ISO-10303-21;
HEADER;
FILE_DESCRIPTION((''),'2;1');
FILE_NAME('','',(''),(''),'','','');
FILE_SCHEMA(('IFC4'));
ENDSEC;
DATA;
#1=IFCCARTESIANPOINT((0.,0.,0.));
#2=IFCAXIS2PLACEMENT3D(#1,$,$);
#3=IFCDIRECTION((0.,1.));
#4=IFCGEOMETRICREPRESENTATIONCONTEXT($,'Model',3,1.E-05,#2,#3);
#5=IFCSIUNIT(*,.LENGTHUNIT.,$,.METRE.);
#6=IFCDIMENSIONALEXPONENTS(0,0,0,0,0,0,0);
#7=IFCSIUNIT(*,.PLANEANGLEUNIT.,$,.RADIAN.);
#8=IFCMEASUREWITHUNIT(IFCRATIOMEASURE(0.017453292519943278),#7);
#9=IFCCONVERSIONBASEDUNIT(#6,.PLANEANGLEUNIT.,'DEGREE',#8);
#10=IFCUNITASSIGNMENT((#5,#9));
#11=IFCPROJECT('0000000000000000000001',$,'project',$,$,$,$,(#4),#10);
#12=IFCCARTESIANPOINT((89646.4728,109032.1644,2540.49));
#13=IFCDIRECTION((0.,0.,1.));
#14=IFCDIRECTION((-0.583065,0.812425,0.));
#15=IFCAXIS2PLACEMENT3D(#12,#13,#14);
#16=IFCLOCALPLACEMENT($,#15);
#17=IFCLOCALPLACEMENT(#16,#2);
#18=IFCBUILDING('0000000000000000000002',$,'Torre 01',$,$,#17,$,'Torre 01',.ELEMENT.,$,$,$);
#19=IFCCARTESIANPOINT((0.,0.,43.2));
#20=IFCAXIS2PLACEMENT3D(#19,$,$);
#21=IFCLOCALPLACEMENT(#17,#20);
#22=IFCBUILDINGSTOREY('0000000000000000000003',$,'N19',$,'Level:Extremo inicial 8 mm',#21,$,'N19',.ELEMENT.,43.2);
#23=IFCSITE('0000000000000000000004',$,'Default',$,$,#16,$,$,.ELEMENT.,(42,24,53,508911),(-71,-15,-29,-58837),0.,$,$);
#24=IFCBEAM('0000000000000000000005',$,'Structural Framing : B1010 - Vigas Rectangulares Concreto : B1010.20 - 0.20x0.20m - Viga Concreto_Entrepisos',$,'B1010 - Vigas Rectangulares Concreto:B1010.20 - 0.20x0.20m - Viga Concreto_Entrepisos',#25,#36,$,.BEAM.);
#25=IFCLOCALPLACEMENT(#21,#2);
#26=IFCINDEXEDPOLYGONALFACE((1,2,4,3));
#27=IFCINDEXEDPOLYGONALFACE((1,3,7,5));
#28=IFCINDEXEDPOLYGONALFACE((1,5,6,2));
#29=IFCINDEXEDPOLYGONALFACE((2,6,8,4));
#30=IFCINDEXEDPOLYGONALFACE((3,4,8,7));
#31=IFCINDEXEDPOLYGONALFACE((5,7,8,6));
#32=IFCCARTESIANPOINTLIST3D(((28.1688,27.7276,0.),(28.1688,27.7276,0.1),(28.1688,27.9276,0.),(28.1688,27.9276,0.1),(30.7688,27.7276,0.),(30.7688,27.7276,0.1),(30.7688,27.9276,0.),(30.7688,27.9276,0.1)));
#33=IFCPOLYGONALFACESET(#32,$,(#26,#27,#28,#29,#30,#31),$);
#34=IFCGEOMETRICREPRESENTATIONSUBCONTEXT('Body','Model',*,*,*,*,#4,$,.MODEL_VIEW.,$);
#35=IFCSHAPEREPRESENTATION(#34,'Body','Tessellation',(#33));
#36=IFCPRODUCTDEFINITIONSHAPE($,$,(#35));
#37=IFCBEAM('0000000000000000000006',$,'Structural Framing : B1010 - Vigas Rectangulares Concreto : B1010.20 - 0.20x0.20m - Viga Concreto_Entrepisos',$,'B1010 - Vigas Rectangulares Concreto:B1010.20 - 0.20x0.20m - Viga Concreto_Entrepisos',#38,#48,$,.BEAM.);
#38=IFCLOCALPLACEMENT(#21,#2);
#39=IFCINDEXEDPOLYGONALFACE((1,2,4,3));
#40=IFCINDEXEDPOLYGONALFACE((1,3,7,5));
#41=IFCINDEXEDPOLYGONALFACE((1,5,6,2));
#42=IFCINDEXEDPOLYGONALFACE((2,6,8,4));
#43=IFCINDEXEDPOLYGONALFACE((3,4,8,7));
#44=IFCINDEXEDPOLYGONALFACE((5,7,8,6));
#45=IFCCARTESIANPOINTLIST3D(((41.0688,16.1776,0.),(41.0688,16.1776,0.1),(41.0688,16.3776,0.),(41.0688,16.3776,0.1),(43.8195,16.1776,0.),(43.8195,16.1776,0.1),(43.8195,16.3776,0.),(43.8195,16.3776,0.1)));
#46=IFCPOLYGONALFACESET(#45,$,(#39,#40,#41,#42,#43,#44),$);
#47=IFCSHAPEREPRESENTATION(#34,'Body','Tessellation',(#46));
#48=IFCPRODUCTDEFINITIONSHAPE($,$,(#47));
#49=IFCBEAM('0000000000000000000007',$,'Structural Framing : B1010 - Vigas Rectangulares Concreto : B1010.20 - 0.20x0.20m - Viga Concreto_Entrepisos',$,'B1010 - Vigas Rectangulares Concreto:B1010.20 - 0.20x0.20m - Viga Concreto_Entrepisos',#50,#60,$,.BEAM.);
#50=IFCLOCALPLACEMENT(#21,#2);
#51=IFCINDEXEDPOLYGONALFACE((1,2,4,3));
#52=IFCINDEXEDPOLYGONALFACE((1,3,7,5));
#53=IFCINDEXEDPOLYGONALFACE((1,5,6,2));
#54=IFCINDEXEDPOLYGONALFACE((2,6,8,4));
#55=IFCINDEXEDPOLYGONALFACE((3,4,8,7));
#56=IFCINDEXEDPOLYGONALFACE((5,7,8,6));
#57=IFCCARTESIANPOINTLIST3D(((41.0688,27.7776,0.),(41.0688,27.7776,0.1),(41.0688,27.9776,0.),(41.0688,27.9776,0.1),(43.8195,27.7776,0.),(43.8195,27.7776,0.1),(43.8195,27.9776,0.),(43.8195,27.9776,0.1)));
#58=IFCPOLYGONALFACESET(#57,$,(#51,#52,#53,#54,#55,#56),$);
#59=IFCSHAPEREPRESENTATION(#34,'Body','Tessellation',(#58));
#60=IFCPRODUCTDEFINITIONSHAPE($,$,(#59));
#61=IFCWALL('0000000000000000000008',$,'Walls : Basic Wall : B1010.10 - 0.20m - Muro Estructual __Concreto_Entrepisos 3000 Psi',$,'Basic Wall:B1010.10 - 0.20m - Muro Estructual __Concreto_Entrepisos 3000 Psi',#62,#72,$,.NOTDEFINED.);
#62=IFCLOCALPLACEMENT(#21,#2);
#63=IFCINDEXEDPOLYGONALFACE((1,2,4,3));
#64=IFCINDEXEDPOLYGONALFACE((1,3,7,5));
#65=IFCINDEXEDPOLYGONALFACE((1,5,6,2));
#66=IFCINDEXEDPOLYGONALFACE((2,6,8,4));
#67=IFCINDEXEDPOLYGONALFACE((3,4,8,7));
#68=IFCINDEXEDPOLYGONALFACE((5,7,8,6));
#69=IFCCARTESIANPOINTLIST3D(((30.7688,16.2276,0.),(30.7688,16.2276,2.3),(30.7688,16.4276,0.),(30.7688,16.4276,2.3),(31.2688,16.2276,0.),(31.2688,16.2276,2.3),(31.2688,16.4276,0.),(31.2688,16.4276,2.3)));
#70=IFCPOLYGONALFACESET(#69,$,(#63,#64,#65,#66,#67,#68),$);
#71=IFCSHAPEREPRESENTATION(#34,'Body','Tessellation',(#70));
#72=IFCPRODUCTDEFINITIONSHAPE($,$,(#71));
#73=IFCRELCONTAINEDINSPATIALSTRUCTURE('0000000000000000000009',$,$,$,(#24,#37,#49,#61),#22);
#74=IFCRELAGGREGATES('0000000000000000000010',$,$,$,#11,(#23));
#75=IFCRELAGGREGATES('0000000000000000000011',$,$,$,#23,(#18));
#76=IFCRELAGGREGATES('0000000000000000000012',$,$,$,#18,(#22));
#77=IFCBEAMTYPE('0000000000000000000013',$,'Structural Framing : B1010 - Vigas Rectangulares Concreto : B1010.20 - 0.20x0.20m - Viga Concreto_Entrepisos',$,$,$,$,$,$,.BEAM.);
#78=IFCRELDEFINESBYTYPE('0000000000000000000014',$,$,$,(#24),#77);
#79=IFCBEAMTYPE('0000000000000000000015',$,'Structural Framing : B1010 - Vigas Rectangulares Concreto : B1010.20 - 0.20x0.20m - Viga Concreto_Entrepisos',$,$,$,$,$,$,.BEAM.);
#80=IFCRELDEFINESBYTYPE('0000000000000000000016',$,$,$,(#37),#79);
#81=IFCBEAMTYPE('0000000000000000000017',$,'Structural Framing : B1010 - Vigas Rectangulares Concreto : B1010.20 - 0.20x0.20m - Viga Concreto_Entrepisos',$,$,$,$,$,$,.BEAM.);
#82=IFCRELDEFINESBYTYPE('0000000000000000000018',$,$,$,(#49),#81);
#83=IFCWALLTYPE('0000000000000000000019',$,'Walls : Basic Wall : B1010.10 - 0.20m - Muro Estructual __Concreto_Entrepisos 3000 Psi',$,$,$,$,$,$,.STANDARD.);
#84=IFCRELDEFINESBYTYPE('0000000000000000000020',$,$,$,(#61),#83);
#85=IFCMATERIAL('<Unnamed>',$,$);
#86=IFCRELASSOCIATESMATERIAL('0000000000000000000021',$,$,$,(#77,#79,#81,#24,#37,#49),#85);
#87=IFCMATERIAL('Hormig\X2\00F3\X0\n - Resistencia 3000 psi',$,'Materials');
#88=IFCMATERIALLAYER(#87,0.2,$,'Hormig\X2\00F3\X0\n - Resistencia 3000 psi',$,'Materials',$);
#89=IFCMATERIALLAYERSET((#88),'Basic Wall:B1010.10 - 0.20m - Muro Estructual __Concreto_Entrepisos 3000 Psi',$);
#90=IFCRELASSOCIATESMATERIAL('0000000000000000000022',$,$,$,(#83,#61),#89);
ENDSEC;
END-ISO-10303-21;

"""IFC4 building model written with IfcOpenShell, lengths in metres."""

from ifc_helpers import new_model, entity, si_unit, converted_unit, direction, frame, frame_2d, origin, origin_2d_with_axis, place, context, subcontext, project, spatial, polyline, segment, composite_curve, rectangle, outline, extrude, source, transform, mapped, material, layer, layer_set, layer_usage, material_profile, profile_set, profile_usage, type_object, type_shapes, element, save


model = new_model("IFC4")

# Units and contexts
model_context = context("Model", 3, precision=1e-05, world=origin(), true_north=direction((0.0, 1.0)))
body_context = subcontext(model_context, "Body", "Model", "MODEL_VIEW")
ifc_project = project(units=[si_unit("LENGTHUNIT", "METRE"), converted_unit("PLANEANGLEUNIT", "DEGREE", entity("IfcRatioMeasure", 0.017453292519943278), si_unit("PLANEANGLEUNIT", "RADIAN"), dimensions=[0, 0, 0, 0, 0, 0, 0])], contexts=[model_context])

# Site, building, storey
site_placement = place(None, frame((89646.4728, 109032.1644, 2540.49), z_axis=(0.0, 0.0, 1.0), x_axis=(-0.583065, 0.812425, 0.0)))
site = spatial("IfcSite", under=ifc_project, at=site_placement, Name="Default", CompositionType="ELEMENT", RefLatitude=(42, 24, 53, 508911), RefLongitude=(-71, -15, -29, -58837), RefElevation=0.0)
building_placement = place(site_placement, origin())
building = spatial("IfcBuilding", under=site, at=building_placement, Name="Torre 01", LongName="Torre 01", CompositionType="ELEMENT")
storey_placement = place(building_placement, frame((0.0, 0.0, 43.2)))
storey = spatial("IfcBuildingStorey", under=building, at=storey_placement, Name="N19", ObjectType="Level:Extremo inicial 8 mm", LongName="N19", CompositionType="ELEMENT", Elevation=43.2)

# Beams
ifc_material_1 = material(Name="<Unnamed>")
ifc_material_profile_1 = material_profile(ifc_material_1, outline(composite_curve([segment(polyline([(-0.1, 0.0, 0.0), (-0.1, 0.1, 0.0)]), True, "CONTINUOUS"), segment(polyline([(-0.1, 0.1, 0.0), (0.1, 0.1, 0.0)]), True, "CONTINUOUS"), segment(polyline([(0.1, 0.1, 0.0), (0.1, 0.0, 0.0)]), True, "CONTINUOUS"), segment(polyline([(0.1, 0.0, 0.0), (-0.1, 0.0, 0.0)]), True, "CONTINUOUS")], self_intersect=False), kind="CURVE"), Name="B1010.20 - 0.20x0.20m - Viga Concreto_Entrepisos")
ifc_material_profile_2 = material_profile(ifc_material_1, outline(composite_curve([segment(polyline([(-1.3, -0.1, 0.1), (-1.3, 0.1, 0.1)]), True, "CONTINUOUS"), segment(polyline([(-1.3, 0.1, 0.1), (-1.3, 0.1, -0.1)]), True, "CONTINUOUS"), segment(polyline([(-1.3, 0.1, -0.1), (-1.3, -0.1, -0.1)]), True, "CONTINUOUS"), segment(polyline([(-1.3, -0.1, -0.1), (-1.3, -0.1, 0.1)]), True, "CONTINUOUS")], self_intersect=False), kind="CURVE"), Name="B1010.20 - 0.20x0.20m - Viga Concreto_Entrepisos")
ifc_profile_set_1 = profile_set([ifc_material_profile_1, ifc_material_profile_2], Name="B1010.20 - 0.20x0.20m - Viga Concreto_Entrepisos")
ifc_profile_usage_1 = profile_usage(ifc_profile_set_1, cardinal=8)
beam_type_1 = type_object("IfcBeamType", Name="Structural Framing : B1010 - Vigas Rectangulares Concreto : B1010.20 - 0.20x0.20m - Viga Concreto_Entrepisos", PredefinedType="BEAM", material=ifc_profile_set_1)
shared_shape_1 = source(origin(), body_context, "Body", "SweptSolid", [
    extrude(rectangle(XDim=0.1, YDim=0.2, at=origin_2d_with_axis()), frame((28.1688, 27.8276, 43.25), z_axis=(1.0, 0.0, 0.0), x_axis=(0.0, 0.0, -1.0)), (0.0, 0.0, 1.0), 2.6),
])
type_shapes(beam_type_1, [shared_shape_1])
beam_1_placement = place(storey_placement, frame((0.0, 0.0, -43.2)))
element("IfcBeam", 1, at=beam_1_placement, inside=storey, type_object=beam_type_1, material=ifc_profile_usage_1, Name="Structural Framing : B1010 - Vigas Rectangulares Concreto : B1010.20 - 0.20x0.20m - Viga Concreto_Entrepisos", ObjectType="B1010 - Vigas Rectangulares Concreto:B1010.20 - 0.20x0.20m - Viga Concreto_Entrepisos", PredefinedType="BEAM", context=body_context, shape_type="MappedRepresentation", body=[
    mapped(shared_shape_1, transform((0.0, 0.0, 0.0), scale=1.0)),
])
ifc_profile_usage_2 = profile_usage(ifc_profile_set_1, cardinal=8)
beam_type_2 = type_object("IfcBeamType", Name="Structural Framing : B1010 - Vigas Rectangulares Concreto : B1010.20 - 0.20x0.20m - Viga Concreto_Entrepisos", PredefinedType="BEAM", material=ifc_profile_set_1)
shared_shape_2 = source(origin(), body_context, "Body", "SweptSolid", [
    extrude(rectangle(XDim=0.1, YDim=0.2, at=frame_2d((0.0, 0.0), x_axis=(1.0, 0.0))), frame((43.8195, 16.2776, 43.25), z_axis=(-1.0, 0.0, 0.0), x_axis=(0.0, 0.0, -1.0)), (0.0, 0.0, 1.0), 2.7507),
])
type_shapes(beam_type_2, [shared_shape_2])
beam_2_placement = place(storey_placement, frame((0.0, 0.0, -43.2)))
element("IfcBeam", 2, at=beam_2_placement, inside=storey, type_object=beam_type_2, material=ifc_profile_usage_2, Name="Structural Framing : B1010 - Vigas Rectangulares Concreto : B1010.20 - 0.20x0.20m - Viga Concreto_Entrepisos", ObjectType="B1010 - Vigas Rectangulares Concreto:B1010.20 - 0.20x0.20m - Viga Concreto_Entrepisos", PredefinedType="BEAM", context=body_context, shape_type="MappedRepresentation", body=[
    mapped(shared_shape_2, transform((0.0, 0.0, 0.0), scale=1.0)),
])
ifc_profile_usage_3 = profile_usage(ifc_profile_set_1, cardinal=8)
beam_type_3 = type_object("IfcBeamType", Name="Structural Framing : B1010 - Vigas Rectangulares Concreto : B1010.20 - 0.20x0.20m - Viga Concreto_Entrepisos", PredefinedType="BEAM", material=ifc_profile_set_1)
shared_shape_3 = source(origin(), body_context, "Body", "SweptSolid", [
    extrude(rectangle(XDim=0.1, YDim=0.2, at=origin_2d_with_axis()), frame((43.8195, 27.8776, 43.25), z_axis=(-1.0, 0.0, 0.0), x_axis=(0.0, 0.0, -1.0)), (0.0, 0.0, 1.0), 2.7507),
])
type_shapes(beam_type_3, [shared_shape_3])
beam_3_placement = place(storey_placement, frame((0.0, 0.0, -43.2)))
element("IfcBeam", 3, at=beam_3_placement, inside=storey, type_object=beam_type_3, material=ifc_profile_usage_3, Name="Structural Framing : B1010 - Vigas Rectangulares Concreto : B1010.20 - 0.20x0.20m - Viga Concreto_Entrepisos", ObjectType="B1010 - Vigas Rectangulares Concreto:B1010.20 - 0.20x0.20m - Viga Concreto_Entrepisos", PredefinedType="BEAM", context=body_context, shape_type="MappedRepresentation", body=[
    mapped(shared_shape_3, transform((0.0, 0.0, 0.0), scale=1.0)),
])

# Wall
ifc_material_2 = material(Name="Hormigón - Resistencia 3000 psi", Category="Materials")
ifc_layer_1 = layer(ifc_material_2, 0.2, Name="Hormigón - Resistencia 3000 psi", Category="Materials")
ifc_layer_set_1 = layer_set([ifc_layer_1], Name="Basic Wall:B1010.10 - 0.20m - Muro Estructual __Concreto_Entrepisos 3000 Psi")
ifc_layer_usage_1 = layer_usage(ifc_layer_set_1, "AXIS2", "NEGATIVE", 0.1)
wall_type = type_object("IfcWallType", Name="Walls : Basic Wall : B1010.10 - 0.20m - Muro Estructual __Concreto_Entrepisos 3000 Psi", PredefinedType="STANDARD", material=ifc_layer_set_1)
wall_placement = place(storey_placement, frame((30.7688, 16.3276, 0.0)))
element("IfcWall", 4, at=wall_placement, inside=storey, type_object=wall_type, material=ifc_layer_usage_1, Name="Walls : Basic Wall : B1010.10 - 0.20m - Muro Estructual __Concreto_Entrepisos 3000 Psi", ObjectType="Basic Wall:B1010.10 - 0.20m - Muro Estructual __Concreto_Entrepisos 3000 Psi", PredefinedType="NOTDEFINED", context=body_context, shape_type="SweptSolid", body=[
    extrude(rectangle(XDim=0.5, YDim=0.2, at=frame_2d((0.25, 0.0), x_axis=(-1.0, 0.0))), origin(), (0.0, 0.0, 1.0), 2.3),
])

save(model, "model.ifc")
